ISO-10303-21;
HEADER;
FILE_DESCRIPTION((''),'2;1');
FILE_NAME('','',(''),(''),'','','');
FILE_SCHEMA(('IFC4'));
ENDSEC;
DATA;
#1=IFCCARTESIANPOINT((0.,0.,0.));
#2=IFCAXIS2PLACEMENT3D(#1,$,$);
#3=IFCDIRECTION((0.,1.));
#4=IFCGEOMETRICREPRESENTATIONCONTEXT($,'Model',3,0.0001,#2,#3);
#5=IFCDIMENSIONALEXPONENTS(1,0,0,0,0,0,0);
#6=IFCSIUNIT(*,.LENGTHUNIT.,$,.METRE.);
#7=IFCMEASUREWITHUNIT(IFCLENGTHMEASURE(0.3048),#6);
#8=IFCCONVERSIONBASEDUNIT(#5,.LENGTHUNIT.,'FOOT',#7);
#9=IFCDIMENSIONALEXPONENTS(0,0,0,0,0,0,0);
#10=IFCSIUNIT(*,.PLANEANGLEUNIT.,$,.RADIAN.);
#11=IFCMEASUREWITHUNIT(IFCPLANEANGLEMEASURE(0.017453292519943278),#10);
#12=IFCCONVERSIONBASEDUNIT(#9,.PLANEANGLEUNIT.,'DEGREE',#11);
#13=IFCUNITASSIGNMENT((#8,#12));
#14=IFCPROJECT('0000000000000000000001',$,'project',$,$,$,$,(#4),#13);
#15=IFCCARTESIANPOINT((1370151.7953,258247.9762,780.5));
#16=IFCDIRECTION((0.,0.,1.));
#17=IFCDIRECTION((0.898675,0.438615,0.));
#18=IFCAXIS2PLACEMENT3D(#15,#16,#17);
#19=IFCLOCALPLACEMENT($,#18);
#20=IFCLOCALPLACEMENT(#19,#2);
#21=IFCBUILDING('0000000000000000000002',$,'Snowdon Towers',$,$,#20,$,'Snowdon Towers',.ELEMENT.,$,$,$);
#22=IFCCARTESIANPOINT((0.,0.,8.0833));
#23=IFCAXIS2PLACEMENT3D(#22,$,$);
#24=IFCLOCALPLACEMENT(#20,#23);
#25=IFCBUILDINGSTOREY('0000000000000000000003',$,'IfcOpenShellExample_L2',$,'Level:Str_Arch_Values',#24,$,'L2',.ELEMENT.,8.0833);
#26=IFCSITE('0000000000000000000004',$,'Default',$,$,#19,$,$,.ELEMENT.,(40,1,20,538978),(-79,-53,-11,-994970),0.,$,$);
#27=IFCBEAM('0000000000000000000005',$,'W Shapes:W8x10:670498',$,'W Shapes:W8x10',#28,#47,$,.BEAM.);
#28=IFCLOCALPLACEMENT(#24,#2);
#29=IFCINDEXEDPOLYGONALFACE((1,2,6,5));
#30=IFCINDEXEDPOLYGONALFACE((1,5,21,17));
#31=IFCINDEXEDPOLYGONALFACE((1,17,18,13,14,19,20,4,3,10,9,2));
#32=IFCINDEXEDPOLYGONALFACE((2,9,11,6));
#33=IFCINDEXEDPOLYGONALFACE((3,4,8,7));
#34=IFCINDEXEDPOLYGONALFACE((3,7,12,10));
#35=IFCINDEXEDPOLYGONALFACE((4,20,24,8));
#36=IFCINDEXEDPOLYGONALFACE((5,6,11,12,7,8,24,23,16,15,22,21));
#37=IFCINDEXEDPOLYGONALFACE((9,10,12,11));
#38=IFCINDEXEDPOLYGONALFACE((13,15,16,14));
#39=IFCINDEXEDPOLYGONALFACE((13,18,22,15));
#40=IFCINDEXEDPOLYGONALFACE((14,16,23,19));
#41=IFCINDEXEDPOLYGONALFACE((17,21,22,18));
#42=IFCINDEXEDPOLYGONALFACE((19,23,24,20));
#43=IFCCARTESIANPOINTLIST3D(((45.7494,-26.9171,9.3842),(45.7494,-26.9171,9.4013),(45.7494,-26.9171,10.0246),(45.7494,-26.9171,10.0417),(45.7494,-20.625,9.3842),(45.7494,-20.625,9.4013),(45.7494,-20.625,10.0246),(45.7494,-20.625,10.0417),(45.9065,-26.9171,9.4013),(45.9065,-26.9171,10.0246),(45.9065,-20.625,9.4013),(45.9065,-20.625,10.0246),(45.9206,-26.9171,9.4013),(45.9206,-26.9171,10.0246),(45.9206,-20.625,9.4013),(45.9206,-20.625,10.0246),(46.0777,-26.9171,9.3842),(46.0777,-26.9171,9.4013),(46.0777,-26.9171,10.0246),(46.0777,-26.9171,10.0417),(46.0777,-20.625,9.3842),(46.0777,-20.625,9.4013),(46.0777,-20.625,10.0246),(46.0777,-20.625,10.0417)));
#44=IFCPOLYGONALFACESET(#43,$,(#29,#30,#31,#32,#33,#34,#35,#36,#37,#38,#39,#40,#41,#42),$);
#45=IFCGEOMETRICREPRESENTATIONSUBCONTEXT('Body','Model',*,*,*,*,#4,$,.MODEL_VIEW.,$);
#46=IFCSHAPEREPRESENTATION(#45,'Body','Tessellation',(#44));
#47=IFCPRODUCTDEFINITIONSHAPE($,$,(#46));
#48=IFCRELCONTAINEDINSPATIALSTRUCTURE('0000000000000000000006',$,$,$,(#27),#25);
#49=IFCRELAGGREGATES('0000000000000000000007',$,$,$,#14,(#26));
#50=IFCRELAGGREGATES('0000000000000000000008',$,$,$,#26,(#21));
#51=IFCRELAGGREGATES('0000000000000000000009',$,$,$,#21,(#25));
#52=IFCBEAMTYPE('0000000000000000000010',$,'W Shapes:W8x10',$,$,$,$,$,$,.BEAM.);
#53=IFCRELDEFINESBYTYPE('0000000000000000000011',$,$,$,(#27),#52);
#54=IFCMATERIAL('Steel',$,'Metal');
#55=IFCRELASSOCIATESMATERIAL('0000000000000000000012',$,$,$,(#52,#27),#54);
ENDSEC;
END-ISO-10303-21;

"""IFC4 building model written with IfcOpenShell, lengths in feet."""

from ifc_helpers import new_model, entity, si_unit, converted_unit, direction, frame, origin, place, context, subcontext, project, spatial, indexed_curve, outline, extrude, source, transform, mapped, material, type_object, type_shapes, element, save


model = new_model("IFC4")

# Units and contexts
model_context = context("Model", 3, precision=0.0001, world=origin(), true_north=direction((0.0, 1.0)))
body_context = subcontext(model_context, "Body", "Model", "MODEL_VIEW")
ifc_project = project(units=[converted_unit("LENGTHUNIT", "FOOT", entity("IfcLengthMeasure", 0.3048), si_unit("LENGTHUNIT", "METRE"), dimensions=[1, 0, 0, 0, 0, 0, 0]), converted_unit("PLANEANGLEUNIT", "DEGREE", entity("IfcPlaneAngleMeasure", 0.017453292519943278), si_unit("PLANEANGLEUNIT", "RADIAN"), dimensions=[0, 0, 0, 0, 0, 0, 0])], contexts=[model_context])

# Site, building, storey
site_placement = place(None, frame((1370151.7953, 258247.9762, 780.5), z_axis=(0.0, 0.0, 1.0), x_axis=(0.898675, 0.438615, 0.0)))
site = spatial("IfcSite", under=ifc_project, at=site_placement, Name="Default", CompositionType="ELEMENT", RefLatitude=(40, 1, 20, 538978), RefLongitude=(-79, -53, -11, -994970), RefElevation=0.0)
building_placement = place(site_placement, origin())
building = spatial("IfcBuilding", under=site, at=building_placement, Name="Snowdon Towers", LongName="Snowdon Towers", CompositionType="ELEMENT")
storey_placement = place(building_placement, frame((0.0, 0.0, 8.0833)))
storey = spatial("IfcBuildingStorey", under=building, at=storey_placement, Name="IfcOpenShellExample_L2", ObjectType="Level:Str_Arch_Values", LongName="L2", CompositionType="ELEMENT", Elevation=8.0833)

# Shared definitions
ifc_material = material(Name="Steel", Category="Metal")

# Beam
beam_type_1 = type_object("IfcBeamType", Name="W Shapes:W8x10", PredefinedType="BEAM", material=ifc_material)
shared_shape_1 = source(origin(), body_context, "Body", "SweptSolid", [
    extrude(outline(indexed_curve([(-0.1642, -0.3117), (-0.1642, -0.3288), (0.1642, -0.3288), (0.1642, -0.3117), (0.0071, -0.3117), (0.0071, 0.3117), (0.1642, 0.3117), (0.1642, 0.3287), (-0.1642, 0.3287), (-0.1642, 0.3117), (-0.0071, 0.3117), (-0.0071, -0.3117), (-0.1642, -0.3117)], self_intersect=False)), frame((-3.0585, 0.0, 0.0), z_axis=(-1.0, 0.0, 0.0), x_axis=(0.0, -1.0, 0.0)), (0.0, 0.0, -1.0), 6.2921),
])
type_shapes(beam_type_1, [shared_shape_1])
beam_1_placement = place(storey_placement, frame((45.9135, -23.6835, 9.7129), z_axis=(0.0, 0.0, 1.0), x_axis=(0.0, -1.0, 0.0)))
element("IfcBeam", 1, at=beam_1_placement, inside=storey, type_object=beam_type_1, material=ifc_material, Name="W Shapes:W8x10:670498", ObjectType="W Shapes:W8x10", PredefinedType="BEAM", context=body_context, shape_type="MappedRepresentation", body=[
    mapped(shared_shape_1, transform((0.0, 0.0, 0.0), scale=1.0)),
])

save(model, "model.ifc")
